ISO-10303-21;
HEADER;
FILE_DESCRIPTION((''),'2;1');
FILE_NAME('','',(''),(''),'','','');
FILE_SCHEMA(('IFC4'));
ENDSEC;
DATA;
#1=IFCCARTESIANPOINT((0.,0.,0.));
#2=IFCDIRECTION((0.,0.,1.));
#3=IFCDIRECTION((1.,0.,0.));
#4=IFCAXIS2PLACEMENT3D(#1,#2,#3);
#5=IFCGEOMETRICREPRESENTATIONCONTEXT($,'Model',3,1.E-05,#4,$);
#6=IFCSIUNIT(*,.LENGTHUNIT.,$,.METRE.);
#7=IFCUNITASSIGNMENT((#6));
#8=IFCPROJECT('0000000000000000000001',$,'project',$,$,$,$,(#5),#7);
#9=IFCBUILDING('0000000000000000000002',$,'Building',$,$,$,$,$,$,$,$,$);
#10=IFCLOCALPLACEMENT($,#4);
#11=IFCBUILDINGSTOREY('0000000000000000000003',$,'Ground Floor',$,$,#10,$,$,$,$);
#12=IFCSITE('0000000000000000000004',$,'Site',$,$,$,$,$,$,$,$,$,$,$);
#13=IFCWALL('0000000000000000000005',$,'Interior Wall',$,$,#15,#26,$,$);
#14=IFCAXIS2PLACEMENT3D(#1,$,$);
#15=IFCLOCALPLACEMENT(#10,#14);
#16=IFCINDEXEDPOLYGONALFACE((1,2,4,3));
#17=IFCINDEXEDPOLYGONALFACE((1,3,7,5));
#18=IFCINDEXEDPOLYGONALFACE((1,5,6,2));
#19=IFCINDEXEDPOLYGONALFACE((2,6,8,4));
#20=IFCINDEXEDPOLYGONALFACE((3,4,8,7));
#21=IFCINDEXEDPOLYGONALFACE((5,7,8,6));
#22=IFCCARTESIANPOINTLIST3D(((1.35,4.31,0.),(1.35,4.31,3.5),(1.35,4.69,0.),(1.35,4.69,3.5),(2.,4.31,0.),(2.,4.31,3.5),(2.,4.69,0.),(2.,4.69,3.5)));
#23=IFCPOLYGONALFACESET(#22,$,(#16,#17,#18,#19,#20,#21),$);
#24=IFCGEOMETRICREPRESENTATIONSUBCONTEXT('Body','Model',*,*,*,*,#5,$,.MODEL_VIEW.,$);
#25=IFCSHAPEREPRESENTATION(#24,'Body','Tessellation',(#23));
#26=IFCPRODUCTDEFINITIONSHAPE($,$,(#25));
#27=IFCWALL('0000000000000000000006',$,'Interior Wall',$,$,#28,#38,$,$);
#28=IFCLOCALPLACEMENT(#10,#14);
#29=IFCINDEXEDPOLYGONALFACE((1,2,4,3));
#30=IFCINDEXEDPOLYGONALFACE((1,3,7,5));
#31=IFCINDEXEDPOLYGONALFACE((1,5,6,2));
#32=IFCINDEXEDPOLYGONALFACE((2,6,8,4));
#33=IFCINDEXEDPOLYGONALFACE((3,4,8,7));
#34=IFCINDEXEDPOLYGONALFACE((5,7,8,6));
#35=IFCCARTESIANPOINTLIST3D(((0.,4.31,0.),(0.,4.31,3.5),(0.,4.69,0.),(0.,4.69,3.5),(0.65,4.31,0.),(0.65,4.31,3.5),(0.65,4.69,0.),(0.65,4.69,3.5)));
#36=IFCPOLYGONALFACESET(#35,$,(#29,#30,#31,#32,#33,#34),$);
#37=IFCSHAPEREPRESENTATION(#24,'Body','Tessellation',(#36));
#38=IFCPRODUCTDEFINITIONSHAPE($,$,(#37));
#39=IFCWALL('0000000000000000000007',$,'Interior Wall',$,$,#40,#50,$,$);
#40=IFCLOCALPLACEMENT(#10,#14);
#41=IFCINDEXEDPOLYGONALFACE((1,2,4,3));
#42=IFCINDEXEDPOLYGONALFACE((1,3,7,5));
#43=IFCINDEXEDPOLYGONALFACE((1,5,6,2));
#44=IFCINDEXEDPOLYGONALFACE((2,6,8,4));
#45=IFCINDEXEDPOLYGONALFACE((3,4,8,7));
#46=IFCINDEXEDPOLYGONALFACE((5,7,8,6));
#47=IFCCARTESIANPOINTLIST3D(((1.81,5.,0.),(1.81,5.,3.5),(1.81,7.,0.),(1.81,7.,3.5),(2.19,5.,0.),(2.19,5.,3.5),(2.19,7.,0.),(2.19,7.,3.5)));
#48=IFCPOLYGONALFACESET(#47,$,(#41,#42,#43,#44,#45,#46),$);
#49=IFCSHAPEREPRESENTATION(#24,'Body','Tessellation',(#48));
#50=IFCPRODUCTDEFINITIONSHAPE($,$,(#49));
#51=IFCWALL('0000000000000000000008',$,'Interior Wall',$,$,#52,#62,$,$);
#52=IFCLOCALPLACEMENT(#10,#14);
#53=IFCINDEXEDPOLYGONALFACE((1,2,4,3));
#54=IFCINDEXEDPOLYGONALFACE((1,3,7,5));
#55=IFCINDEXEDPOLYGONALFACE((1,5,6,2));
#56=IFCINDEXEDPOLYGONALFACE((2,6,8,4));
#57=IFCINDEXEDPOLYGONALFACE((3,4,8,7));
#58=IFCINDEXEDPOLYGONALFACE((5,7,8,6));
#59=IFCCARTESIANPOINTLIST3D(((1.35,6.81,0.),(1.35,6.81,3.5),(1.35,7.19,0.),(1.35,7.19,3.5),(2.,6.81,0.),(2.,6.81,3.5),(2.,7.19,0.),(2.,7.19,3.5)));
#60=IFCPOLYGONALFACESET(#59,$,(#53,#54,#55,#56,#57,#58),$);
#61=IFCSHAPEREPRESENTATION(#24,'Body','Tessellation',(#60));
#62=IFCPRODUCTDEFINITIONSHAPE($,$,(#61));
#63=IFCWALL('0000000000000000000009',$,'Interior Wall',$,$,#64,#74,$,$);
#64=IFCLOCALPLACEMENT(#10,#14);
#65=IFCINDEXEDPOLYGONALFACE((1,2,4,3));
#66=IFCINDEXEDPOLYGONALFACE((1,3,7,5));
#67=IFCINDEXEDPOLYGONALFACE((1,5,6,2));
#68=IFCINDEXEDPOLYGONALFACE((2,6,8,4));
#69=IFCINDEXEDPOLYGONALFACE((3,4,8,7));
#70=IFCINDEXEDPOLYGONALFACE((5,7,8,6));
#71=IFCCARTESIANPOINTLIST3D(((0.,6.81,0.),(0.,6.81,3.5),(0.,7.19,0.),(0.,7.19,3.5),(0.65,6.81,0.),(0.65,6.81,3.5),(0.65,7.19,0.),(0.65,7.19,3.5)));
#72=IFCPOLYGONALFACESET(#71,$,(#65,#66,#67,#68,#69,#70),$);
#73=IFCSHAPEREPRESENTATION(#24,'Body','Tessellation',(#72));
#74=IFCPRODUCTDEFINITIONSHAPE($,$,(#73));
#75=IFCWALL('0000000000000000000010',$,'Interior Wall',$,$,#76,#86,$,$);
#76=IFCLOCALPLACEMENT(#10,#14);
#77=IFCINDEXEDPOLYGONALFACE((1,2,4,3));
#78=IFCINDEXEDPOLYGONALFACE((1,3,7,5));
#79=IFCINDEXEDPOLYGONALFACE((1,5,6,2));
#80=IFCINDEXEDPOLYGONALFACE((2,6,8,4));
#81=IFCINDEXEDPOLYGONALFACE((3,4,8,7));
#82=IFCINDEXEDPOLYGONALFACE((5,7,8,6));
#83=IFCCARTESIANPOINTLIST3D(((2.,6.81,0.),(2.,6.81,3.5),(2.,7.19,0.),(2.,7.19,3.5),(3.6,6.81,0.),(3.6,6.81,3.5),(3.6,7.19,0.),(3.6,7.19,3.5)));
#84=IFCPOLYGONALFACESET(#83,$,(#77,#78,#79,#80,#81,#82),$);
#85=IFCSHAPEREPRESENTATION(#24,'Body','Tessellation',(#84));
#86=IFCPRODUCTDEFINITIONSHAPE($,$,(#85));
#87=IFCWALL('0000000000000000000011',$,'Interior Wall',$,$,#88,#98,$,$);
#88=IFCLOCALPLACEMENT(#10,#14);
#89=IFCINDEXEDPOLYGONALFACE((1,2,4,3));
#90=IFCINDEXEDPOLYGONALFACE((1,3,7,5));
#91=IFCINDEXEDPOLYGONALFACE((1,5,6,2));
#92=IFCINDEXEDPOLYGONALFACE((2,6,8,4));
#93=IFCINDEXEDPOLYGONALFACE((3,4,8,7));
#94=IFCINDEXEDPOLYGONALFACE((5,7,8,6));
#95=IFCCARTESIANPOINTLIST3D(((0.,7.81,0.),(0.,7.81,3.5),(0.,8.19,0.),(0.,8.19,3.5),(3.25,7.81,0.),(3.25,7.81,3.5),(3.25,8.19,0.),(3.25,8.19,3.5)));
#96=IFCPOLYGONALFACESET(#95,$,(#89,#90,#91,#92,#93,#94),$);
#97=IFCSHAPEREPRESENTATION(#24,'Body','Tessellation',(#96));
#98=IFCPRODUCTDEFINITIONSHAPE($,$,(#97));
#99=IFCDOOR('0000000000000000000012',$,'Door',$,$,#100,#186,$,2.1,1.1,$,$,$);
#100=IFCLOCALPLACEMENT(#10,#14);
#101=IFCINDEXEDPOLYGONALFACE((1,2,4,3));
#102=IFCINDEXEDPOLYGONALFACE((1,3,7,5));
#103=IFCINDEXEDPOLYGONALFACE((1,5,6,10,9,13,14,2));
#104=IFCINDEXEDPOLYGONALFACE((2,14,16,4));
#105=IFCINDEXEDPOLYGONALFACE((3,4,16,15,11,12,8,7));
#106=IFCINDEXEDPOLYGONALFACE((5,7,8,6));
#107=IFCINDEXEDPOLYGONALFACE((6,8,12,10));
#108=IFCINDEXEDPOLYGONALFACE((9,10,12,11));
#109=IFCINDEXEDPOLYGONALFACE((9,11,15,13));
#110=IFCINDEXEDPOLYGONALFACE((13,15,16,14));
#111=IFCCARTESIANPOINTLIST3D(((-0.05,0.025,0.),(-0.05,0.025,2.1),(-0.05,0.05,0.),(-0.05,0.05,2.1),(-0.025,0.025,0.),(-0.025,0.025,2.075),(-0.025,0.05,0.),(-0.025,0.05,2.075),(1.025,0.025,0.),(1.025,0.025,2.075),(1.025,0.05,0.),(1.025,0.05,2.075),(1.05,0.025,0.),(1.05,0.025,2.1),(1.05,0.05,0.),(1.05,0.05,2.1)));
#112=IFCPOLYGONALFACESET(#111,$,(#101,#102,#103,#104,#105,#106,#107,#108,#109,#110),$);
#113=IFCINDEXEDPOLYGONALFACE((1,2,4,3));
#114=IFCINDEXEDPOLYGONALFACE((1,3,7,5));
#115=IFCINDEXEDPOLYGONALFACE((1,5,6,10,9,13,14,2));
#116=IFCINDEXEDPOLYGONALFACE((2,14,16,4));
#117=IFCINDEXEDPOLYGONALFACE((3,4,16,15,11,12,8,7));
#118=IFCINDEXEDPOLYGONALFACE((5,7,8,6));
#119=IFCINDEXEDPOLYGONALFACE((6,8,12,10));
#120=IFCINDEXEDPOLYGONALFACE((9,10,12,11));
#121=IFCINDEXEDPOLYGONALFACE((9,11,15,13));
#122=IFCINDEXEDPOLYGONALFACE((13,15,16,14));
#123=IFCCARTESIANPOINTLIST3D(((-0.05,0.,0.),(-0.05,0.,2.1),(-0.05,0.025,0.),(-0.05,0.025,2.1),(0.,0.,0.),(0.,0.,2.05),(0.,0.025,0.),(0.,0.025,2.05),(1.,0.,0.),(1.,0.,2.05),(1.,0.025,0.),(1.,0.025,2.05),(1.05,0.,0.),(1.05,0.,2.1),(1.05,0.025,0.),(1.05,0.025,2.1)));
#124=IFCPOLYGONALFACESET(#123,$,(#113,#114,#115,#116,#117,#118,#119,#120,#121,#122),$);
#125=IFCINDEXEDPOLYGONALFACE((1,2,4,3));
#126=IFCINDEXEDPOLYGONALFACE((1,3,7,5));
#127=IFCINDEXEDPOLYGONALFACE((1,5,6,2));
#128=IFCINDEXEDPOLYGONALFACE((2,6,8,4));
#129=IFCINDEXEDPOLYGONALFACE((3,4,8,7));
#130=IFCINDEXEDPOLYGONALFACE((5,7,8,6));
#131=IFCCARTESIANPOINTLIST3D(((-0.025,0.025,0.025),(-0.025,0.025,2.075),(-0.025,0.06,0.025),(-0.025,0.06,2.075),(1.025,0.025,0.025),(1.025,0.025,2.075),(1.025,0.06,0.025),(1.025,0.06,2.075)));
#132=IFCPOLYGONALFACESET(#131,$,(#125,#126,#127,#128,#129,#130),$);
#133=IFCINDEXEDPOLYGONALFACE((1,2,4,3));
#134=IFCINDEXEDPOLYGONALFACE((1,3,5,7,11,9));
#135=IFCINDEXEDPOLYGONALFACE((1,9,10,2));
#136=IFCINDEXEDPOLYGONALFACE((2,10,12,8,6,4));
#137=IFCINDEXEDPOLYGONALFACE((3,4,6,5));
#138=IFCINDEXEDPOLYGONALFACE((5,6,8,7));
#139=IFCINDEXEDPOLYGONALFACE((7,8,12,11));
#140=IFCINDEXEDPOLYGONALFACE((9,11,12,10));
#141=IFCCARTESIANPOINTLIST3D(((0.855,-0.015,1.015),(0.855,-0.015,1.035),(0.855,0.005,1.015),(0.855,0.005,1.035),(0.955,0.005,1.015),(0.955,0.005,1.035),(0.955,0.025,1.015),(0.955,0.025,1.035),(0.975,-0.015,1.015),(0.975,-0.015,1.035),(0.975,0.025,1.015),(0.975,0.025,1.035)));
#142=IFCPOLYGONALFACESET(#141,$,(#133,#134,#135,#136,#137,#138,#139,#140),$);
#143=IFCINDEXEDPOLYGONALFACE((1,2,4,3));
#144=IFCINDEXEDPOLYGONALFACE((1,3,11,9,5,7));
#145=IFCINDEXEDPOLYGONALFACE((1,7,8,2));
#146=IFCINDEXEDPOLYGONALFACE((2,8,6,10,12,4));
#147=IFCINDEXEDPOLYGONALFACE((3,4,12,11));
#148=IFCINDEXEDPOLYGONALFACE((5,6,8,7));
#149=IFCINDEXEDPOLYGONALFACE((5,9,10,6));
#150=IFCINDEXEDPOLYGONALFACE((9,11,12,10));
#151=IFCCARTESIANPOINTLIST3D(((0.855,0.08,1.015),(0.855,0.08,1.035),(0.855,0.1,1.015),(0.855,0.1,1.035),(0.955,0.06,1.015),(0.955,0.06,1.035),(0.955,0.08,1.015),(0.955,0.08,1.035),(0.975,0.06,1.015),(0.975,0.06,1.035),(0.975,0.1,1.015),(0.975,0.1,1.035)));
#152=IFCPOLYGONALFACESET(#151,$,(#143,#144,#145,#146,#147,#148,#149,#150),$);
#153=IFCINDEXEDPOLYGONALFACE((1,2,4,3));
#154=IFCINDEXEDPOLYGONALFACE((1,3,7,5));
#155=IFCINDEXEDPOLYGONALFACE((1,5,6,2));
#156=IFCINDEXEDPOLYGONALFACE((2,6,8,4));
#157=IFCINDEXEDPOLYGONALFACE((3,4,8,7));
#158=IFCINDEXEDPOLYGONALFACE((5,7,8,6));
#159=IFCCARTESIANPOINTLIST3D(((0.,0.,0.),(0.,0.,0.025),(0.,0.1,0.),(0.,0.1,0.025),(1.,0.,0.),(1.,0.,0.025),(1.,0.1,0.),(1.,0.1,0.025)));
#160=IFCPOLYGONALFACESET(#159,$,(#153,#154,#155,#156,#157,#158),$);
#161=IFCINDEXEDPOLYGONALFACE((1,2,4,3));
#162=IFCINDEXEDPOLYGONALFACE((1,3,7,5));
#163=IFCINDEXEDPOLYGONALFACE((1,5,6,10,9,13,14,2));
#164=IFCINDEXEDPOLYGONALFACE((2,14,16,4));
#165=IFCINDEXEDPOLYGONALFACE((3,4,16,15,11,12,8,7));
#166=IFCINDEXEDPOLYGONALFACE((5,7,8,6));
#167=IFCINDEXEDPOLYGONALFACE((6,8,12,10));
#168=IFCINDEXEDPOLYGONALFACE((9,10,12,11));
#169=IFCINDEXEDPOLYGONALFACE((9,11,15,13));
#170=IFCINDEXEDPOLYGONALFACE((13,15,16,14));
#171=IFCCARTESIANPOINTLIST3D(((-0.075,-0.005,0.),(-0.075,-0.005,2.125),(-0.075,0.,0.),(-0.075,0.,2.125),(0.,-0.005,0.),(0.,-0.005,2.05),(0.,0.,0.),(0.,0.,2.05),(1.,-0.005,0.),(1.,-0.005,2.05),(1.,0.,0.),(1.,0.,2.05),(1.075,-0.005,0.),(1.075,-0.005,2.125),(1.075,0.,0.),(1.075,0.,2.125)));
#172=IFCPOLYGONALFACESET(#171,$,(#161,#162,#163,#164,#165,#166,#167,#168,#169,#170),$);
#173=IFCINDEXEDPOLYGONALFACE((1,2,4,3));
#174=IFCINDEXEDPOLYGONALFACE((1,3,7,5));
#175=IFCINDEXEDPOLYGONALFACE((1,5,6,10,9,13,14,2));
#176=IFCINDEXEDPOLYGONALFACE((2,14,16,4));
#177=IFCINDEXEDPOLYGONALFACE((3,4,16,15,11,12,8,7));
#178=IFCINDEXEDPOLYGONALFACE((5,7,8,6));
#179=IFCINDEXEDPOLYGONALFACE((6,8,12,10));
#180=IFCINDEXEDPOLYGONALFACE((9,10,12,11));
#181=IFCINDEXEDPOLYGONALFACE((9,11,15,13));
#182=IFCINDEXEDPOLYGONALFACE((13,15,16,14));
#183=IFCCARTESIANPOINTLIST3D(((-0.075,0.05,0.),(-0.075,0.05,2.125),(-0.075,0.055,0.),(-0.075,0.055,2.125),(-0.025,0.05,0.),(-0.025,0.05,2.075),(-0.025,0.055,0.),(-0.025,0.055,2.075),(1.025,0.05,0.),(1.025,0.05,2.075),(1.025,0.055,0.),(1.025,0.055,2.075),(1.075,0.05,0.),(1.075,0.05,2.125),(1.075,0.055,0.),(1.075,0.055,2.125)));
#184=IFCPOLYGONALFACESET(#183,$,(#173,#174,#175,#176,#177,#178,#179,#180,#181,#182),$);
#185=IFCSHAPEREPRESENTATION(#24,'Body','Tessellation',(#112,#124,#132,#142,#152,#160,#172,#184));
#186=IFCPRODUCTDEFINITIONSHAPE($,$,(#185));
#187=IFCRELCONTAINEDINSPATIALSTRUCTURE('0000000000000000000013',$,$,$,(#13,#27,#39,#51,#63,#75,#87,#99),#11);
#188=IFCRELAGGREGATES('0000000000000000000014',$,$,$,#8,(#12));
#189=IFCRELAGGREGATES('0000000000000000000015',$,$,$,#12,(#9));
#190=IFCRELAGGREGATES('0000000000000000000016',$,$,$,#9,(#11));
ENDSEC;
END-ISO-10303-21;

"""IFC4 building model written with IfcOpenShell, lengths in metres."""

from ifc_helpers import new_model, si_unit, frame, origin_with_axes, place, context, subcontext, project, spatial, line, indexed_curve, outline, extrude, element, save


model = new_model("IFC4")

# Units and contexts
model_context = context("Model", 3, precision=1e-05, world=origin_with_axes())
body_context = subcontext(model_context, "Body", "Model", "MODEL_VIEW")
ifc_project = project(units=[si_unit("LENGTHUNIT", "METRE")], contexts=[model_context])

# Site, building, storey
site = spatial("IfcSite", under=ifc_project, Name="Site")
building = spatial("IfcBuilding", under=site, Name="Building")
storey_placement = place(None, origin_with_axes())
storey = spatial("IfcBuildingStorey", under=building, at=storey_placement, Name="Ground Floor")

# Walls
for number, where, z_axis, x_axis, name in (
    (1, (2.0, 4.5, 0.0), (0.0, 0.0, 1.0), (-1.0, 0.0, 0.0), "Interior Wall"),
    (2, (0.65, 4.5, 0.0), (0.0, 0.0, 1.0), (-1.0, 0.0, 0.0), "Interior Wall"),
):
    element("IfcWall", number, at=place(storey_placement, frame(where, z_axis=z_axis, x_axis=x_axis)), inside=storey, Name=name, context=body_context, shape_type="SweptSolid", body=[
        extrude(outline(indexed_curve([(0.0, 0.0), (0.0, 0.38), (0.65, 0.38), (0.65, 0.0), (0.0, 0.0)], self_intersect=False)), frame((0.0, -0.19, 0.0), z_axis=(0.0, 0.0, 1.0), x_axis=(1.0, 0.0, 0.0)), (0.0, 0.0, 1.0), 3.5),
    ])
wall_1_placement = place(storey_placement, frame((2.0, 5.0, 0.0), z_axis=(0.0, 0.0, 1.0), x_axis=(0.0, 1.0, 0.0)))
element("IfcWall", 3, at=wall_1_placement, inside=storey, Name="Interior Wall", context=body_context, shape_type="SweptSolid", body=[
    extrude(outline(indexed_curve([(0.0, 0.0), (0.0, 0.38), (2.0, 0.38), (2.0, 0.0), (0.0, 0.0)], self_intersect=False)), frame((0.0, -0.19, 0.0), z_axis=(0.0, 0.0, 1.0), x_axis=(1.0, 0.0, 0.0)), (0.0, 0.0, 1.0), 3.5),
])
for number, where, z_axis, x_axis, name in (
    (4, (2.0, 7.0, 0.0), (0.0, 0.0, 1.0), (-1.0, 0.0, 0.0), "Interior Wall"),
    (5, (0.65, 7.0, 0.0), (0.0, 0.0, 1.0), (-1.0, 0.0, 0.0), "Interior Wall"),
):
    element("IfcWall", number, at=place(storey_placement, frame(where, z_axis=z_axis, x_axis=x_axis)), inside=storey, Name=name, context=body_context, shape_type="SweptSolid", body=[
        extrude(outline(indexed_curve([(0.0, 0.0), (0.0, 0.38), (0.65, 0.38), (0.65, 0.0), (0.0, 0.0)], self_intersect=False)), frame((0.0, -0.19, 0.0), z_axis=(0.0, 0.0, 1.0), x_axis=(1.0, 0.0, 0.0)), (0.0, 0.0, 1.0), 3.5),
    ])
wall_2_placement = place(storey_placement, frame((3.6, 7.0, 0.0), z_axis=(0.0, 0.0, 1.0), x_axis=(-1.0, 0.0, 0.0)))
element("IfcWall", 6, at=wall_2_placement, inside=storey, Name="Interior Wall", context=body_context, shape_type="SweptSolid", body=[
    extrude(outline(indexed_curve([(0.0, 0.0), (0.0, 0.38), (1.6, 0.38), (1.6, 0.0), (0.0, 0.0)], self_intersect=False)), frame((0.0, -0.19, 0.0), z_axis=(0.0, 0.0, 1.0), x_axis=(1.0, 0.0, 0.0)), (0.0, 0.0, 1.0), 3.5),
])
wall_3_placement = place(storey_placement, frame((3.25, 8.0, 0.0), z_axis=(0.0, 0.0, 1.0), x_axis=(-1.0, 0.0, 0.0)))
element("IfcWall", 7, at=wall_3_placement, inside=storey, Name="Interior Wall", context=body_context, shape_type="SweptSolid", body=[
    extrude(outline(indexed_curve([(0.0, 0.0), (0.0, 0.38), (3.25, 0.38), (3.25, 0.0), (0.0, 0.0)], self_intersect=False)), frame((0.0, -0.19, 0.0), z_axis=(0.0, 0.0, 1.0), x_axis=(1.0, 0.0, 0.0)), (0.0, 0.0, 1.0), 3.5),
])

# Door
door_1_placement = place(storey_placement, frame((-0.05, 0.0, 0.0), z_axis=(0.0, 0.0, 1.0), x_axis=(1.0, 0.0, 0.0)))
element("IfcDoor", 8, at=door_1_placement, inside=storey, Name="Door", OverallHeight=2.1, OverallWidth=1.1, context=body_context, shape_type="SweptSolid", body=[
    extrude(outline(indexed_curve([(0.0, 0.0), (0.0, 2.1), (1.1, 2.1), (1.1, 0.0), (1.075, 0.0), (1.075, 2.075), (0.025, 2.075), (0.025, 0.0)], segments=[line(1, 2, 3, 4, 5, 6, 7, 8, 1)])), frame((0.0, 0.025, 0.0), z_axis=(0.0, -1.0, 0.0), x_axis=(1.0, 0.0, 0.0)), (0.0, 0.0, -1.0), 0.025),
    extrude(outline(indexed_curve([(0.0, 0.0), (0.0, 2.1), (1.1, 2.1), (1.1, 0.0), (1.05, 0.0), (1.05, 2.05), (0.05, 2.05), (0.05, 0.0)], segments=[line(1, 2, 3, 4, 5, 6, 7, 8, 1)])), frame((0.0, 0.0, 0.0), z_axis=(0.0, -1.0, 0.0), x_axis=(1.0, 0.0, 0.0)), (0.0, 0.0, -1.0), 0.025),
    extrude(outline(indexed_curve([(0.0, 0.0), (1.05, 0.0), (1.05, 0.035), (0.0, 0.035)], segments=[line(1, 2, 3, 4, 1)])), frame((0.025, 0.025, 0.025), z_axis=(0.0, 0.0, 1.0), x_axis=(1.0, 0.0, 0.0)), (0.0, 0.0, 1.0), 2.05),
    extrude(outline(indexed_curve([(0.0, 0.0), (0.0, -0.04), (-0.12, -0.04), (-0.12, -0.02), (-0.02, -0.02), (-0.02, 0.0)], segments=[line(1, 2, 3, 4, 5, 6, 1)])), frame((1.025, 0.025, 1.015), z_axis=(0.0, 0.0, 1.0), x_axis=(1.0, 0.0, 0.0)), (0.0, 0.0, 1.0), 0.02),
    extrude(outline(indexed_curve([(0.0, 0.0), (0.0, 0.04), (-0.12, 0.04), (-0.12, 0.02), (-0.02, 0.02), (-0.02, 0.0)], segments=[line(1, 2, 3, 4, 5, 6, 1)])), frame((1.025, 0.06, 1.015), z_axis=(0.0, 0.0, 1.0), x_axis=(1.0, 0.0, 0.0)), (0.0, 0.0, 1.0), 0.02),
    extrude(outline(indexed_curve([(0.0, 0.0), (1.0, 0.0), (1.0, 0.1), (0.0, 0.1)], segments=[line(1, 2, 3, 4, 1)])), frame((0.05, 0.0, 0.0), z_axis=(0.0, 0.0, 1.0), x_axis=(1.0, 0.0, 0.0)), (0.0, 0.0, 1.0), 0.025),
    extrude(outline(indexed_curve([(0.0, 0.0), (0.0, 2.125), (1.15, 2.125), (1.15, 0.0), (1.075, 0.0), (1.075, 2.05), (0.075, 2.05), (0.075, 0.0)], segments=[line(1, 2, 3, 4, 5, 6, 7, 8, 1)])), frame((-0.025, -0.005, 0.0), z_axis=(0.0, -1.0, 0.0), x_axis=(1.0, 0.0, 0.0)), (0.0, 0.0, -1.0), 0.005),
    extrude(outline(indexed_curve([(0.0, 0.0), (0.0, 2.125), (1.15, 2.125), (1.15, 0.0), (1.1, 0.0), (1.1, 2.075), (0.05, 2.075), (0.05, 0.0)], segments=[line(1, 2, 3, 4, 5, 6, 7, 8, 1)])), frame((-0.025, 0.05, 0.0), z_axis=(0.0, -1.0, 0.0), x_axis=(1.0, 0.0, 0.0)), (0.0, 0.0, -1.0), 0.005),
])

save(model, "model.ifc")
